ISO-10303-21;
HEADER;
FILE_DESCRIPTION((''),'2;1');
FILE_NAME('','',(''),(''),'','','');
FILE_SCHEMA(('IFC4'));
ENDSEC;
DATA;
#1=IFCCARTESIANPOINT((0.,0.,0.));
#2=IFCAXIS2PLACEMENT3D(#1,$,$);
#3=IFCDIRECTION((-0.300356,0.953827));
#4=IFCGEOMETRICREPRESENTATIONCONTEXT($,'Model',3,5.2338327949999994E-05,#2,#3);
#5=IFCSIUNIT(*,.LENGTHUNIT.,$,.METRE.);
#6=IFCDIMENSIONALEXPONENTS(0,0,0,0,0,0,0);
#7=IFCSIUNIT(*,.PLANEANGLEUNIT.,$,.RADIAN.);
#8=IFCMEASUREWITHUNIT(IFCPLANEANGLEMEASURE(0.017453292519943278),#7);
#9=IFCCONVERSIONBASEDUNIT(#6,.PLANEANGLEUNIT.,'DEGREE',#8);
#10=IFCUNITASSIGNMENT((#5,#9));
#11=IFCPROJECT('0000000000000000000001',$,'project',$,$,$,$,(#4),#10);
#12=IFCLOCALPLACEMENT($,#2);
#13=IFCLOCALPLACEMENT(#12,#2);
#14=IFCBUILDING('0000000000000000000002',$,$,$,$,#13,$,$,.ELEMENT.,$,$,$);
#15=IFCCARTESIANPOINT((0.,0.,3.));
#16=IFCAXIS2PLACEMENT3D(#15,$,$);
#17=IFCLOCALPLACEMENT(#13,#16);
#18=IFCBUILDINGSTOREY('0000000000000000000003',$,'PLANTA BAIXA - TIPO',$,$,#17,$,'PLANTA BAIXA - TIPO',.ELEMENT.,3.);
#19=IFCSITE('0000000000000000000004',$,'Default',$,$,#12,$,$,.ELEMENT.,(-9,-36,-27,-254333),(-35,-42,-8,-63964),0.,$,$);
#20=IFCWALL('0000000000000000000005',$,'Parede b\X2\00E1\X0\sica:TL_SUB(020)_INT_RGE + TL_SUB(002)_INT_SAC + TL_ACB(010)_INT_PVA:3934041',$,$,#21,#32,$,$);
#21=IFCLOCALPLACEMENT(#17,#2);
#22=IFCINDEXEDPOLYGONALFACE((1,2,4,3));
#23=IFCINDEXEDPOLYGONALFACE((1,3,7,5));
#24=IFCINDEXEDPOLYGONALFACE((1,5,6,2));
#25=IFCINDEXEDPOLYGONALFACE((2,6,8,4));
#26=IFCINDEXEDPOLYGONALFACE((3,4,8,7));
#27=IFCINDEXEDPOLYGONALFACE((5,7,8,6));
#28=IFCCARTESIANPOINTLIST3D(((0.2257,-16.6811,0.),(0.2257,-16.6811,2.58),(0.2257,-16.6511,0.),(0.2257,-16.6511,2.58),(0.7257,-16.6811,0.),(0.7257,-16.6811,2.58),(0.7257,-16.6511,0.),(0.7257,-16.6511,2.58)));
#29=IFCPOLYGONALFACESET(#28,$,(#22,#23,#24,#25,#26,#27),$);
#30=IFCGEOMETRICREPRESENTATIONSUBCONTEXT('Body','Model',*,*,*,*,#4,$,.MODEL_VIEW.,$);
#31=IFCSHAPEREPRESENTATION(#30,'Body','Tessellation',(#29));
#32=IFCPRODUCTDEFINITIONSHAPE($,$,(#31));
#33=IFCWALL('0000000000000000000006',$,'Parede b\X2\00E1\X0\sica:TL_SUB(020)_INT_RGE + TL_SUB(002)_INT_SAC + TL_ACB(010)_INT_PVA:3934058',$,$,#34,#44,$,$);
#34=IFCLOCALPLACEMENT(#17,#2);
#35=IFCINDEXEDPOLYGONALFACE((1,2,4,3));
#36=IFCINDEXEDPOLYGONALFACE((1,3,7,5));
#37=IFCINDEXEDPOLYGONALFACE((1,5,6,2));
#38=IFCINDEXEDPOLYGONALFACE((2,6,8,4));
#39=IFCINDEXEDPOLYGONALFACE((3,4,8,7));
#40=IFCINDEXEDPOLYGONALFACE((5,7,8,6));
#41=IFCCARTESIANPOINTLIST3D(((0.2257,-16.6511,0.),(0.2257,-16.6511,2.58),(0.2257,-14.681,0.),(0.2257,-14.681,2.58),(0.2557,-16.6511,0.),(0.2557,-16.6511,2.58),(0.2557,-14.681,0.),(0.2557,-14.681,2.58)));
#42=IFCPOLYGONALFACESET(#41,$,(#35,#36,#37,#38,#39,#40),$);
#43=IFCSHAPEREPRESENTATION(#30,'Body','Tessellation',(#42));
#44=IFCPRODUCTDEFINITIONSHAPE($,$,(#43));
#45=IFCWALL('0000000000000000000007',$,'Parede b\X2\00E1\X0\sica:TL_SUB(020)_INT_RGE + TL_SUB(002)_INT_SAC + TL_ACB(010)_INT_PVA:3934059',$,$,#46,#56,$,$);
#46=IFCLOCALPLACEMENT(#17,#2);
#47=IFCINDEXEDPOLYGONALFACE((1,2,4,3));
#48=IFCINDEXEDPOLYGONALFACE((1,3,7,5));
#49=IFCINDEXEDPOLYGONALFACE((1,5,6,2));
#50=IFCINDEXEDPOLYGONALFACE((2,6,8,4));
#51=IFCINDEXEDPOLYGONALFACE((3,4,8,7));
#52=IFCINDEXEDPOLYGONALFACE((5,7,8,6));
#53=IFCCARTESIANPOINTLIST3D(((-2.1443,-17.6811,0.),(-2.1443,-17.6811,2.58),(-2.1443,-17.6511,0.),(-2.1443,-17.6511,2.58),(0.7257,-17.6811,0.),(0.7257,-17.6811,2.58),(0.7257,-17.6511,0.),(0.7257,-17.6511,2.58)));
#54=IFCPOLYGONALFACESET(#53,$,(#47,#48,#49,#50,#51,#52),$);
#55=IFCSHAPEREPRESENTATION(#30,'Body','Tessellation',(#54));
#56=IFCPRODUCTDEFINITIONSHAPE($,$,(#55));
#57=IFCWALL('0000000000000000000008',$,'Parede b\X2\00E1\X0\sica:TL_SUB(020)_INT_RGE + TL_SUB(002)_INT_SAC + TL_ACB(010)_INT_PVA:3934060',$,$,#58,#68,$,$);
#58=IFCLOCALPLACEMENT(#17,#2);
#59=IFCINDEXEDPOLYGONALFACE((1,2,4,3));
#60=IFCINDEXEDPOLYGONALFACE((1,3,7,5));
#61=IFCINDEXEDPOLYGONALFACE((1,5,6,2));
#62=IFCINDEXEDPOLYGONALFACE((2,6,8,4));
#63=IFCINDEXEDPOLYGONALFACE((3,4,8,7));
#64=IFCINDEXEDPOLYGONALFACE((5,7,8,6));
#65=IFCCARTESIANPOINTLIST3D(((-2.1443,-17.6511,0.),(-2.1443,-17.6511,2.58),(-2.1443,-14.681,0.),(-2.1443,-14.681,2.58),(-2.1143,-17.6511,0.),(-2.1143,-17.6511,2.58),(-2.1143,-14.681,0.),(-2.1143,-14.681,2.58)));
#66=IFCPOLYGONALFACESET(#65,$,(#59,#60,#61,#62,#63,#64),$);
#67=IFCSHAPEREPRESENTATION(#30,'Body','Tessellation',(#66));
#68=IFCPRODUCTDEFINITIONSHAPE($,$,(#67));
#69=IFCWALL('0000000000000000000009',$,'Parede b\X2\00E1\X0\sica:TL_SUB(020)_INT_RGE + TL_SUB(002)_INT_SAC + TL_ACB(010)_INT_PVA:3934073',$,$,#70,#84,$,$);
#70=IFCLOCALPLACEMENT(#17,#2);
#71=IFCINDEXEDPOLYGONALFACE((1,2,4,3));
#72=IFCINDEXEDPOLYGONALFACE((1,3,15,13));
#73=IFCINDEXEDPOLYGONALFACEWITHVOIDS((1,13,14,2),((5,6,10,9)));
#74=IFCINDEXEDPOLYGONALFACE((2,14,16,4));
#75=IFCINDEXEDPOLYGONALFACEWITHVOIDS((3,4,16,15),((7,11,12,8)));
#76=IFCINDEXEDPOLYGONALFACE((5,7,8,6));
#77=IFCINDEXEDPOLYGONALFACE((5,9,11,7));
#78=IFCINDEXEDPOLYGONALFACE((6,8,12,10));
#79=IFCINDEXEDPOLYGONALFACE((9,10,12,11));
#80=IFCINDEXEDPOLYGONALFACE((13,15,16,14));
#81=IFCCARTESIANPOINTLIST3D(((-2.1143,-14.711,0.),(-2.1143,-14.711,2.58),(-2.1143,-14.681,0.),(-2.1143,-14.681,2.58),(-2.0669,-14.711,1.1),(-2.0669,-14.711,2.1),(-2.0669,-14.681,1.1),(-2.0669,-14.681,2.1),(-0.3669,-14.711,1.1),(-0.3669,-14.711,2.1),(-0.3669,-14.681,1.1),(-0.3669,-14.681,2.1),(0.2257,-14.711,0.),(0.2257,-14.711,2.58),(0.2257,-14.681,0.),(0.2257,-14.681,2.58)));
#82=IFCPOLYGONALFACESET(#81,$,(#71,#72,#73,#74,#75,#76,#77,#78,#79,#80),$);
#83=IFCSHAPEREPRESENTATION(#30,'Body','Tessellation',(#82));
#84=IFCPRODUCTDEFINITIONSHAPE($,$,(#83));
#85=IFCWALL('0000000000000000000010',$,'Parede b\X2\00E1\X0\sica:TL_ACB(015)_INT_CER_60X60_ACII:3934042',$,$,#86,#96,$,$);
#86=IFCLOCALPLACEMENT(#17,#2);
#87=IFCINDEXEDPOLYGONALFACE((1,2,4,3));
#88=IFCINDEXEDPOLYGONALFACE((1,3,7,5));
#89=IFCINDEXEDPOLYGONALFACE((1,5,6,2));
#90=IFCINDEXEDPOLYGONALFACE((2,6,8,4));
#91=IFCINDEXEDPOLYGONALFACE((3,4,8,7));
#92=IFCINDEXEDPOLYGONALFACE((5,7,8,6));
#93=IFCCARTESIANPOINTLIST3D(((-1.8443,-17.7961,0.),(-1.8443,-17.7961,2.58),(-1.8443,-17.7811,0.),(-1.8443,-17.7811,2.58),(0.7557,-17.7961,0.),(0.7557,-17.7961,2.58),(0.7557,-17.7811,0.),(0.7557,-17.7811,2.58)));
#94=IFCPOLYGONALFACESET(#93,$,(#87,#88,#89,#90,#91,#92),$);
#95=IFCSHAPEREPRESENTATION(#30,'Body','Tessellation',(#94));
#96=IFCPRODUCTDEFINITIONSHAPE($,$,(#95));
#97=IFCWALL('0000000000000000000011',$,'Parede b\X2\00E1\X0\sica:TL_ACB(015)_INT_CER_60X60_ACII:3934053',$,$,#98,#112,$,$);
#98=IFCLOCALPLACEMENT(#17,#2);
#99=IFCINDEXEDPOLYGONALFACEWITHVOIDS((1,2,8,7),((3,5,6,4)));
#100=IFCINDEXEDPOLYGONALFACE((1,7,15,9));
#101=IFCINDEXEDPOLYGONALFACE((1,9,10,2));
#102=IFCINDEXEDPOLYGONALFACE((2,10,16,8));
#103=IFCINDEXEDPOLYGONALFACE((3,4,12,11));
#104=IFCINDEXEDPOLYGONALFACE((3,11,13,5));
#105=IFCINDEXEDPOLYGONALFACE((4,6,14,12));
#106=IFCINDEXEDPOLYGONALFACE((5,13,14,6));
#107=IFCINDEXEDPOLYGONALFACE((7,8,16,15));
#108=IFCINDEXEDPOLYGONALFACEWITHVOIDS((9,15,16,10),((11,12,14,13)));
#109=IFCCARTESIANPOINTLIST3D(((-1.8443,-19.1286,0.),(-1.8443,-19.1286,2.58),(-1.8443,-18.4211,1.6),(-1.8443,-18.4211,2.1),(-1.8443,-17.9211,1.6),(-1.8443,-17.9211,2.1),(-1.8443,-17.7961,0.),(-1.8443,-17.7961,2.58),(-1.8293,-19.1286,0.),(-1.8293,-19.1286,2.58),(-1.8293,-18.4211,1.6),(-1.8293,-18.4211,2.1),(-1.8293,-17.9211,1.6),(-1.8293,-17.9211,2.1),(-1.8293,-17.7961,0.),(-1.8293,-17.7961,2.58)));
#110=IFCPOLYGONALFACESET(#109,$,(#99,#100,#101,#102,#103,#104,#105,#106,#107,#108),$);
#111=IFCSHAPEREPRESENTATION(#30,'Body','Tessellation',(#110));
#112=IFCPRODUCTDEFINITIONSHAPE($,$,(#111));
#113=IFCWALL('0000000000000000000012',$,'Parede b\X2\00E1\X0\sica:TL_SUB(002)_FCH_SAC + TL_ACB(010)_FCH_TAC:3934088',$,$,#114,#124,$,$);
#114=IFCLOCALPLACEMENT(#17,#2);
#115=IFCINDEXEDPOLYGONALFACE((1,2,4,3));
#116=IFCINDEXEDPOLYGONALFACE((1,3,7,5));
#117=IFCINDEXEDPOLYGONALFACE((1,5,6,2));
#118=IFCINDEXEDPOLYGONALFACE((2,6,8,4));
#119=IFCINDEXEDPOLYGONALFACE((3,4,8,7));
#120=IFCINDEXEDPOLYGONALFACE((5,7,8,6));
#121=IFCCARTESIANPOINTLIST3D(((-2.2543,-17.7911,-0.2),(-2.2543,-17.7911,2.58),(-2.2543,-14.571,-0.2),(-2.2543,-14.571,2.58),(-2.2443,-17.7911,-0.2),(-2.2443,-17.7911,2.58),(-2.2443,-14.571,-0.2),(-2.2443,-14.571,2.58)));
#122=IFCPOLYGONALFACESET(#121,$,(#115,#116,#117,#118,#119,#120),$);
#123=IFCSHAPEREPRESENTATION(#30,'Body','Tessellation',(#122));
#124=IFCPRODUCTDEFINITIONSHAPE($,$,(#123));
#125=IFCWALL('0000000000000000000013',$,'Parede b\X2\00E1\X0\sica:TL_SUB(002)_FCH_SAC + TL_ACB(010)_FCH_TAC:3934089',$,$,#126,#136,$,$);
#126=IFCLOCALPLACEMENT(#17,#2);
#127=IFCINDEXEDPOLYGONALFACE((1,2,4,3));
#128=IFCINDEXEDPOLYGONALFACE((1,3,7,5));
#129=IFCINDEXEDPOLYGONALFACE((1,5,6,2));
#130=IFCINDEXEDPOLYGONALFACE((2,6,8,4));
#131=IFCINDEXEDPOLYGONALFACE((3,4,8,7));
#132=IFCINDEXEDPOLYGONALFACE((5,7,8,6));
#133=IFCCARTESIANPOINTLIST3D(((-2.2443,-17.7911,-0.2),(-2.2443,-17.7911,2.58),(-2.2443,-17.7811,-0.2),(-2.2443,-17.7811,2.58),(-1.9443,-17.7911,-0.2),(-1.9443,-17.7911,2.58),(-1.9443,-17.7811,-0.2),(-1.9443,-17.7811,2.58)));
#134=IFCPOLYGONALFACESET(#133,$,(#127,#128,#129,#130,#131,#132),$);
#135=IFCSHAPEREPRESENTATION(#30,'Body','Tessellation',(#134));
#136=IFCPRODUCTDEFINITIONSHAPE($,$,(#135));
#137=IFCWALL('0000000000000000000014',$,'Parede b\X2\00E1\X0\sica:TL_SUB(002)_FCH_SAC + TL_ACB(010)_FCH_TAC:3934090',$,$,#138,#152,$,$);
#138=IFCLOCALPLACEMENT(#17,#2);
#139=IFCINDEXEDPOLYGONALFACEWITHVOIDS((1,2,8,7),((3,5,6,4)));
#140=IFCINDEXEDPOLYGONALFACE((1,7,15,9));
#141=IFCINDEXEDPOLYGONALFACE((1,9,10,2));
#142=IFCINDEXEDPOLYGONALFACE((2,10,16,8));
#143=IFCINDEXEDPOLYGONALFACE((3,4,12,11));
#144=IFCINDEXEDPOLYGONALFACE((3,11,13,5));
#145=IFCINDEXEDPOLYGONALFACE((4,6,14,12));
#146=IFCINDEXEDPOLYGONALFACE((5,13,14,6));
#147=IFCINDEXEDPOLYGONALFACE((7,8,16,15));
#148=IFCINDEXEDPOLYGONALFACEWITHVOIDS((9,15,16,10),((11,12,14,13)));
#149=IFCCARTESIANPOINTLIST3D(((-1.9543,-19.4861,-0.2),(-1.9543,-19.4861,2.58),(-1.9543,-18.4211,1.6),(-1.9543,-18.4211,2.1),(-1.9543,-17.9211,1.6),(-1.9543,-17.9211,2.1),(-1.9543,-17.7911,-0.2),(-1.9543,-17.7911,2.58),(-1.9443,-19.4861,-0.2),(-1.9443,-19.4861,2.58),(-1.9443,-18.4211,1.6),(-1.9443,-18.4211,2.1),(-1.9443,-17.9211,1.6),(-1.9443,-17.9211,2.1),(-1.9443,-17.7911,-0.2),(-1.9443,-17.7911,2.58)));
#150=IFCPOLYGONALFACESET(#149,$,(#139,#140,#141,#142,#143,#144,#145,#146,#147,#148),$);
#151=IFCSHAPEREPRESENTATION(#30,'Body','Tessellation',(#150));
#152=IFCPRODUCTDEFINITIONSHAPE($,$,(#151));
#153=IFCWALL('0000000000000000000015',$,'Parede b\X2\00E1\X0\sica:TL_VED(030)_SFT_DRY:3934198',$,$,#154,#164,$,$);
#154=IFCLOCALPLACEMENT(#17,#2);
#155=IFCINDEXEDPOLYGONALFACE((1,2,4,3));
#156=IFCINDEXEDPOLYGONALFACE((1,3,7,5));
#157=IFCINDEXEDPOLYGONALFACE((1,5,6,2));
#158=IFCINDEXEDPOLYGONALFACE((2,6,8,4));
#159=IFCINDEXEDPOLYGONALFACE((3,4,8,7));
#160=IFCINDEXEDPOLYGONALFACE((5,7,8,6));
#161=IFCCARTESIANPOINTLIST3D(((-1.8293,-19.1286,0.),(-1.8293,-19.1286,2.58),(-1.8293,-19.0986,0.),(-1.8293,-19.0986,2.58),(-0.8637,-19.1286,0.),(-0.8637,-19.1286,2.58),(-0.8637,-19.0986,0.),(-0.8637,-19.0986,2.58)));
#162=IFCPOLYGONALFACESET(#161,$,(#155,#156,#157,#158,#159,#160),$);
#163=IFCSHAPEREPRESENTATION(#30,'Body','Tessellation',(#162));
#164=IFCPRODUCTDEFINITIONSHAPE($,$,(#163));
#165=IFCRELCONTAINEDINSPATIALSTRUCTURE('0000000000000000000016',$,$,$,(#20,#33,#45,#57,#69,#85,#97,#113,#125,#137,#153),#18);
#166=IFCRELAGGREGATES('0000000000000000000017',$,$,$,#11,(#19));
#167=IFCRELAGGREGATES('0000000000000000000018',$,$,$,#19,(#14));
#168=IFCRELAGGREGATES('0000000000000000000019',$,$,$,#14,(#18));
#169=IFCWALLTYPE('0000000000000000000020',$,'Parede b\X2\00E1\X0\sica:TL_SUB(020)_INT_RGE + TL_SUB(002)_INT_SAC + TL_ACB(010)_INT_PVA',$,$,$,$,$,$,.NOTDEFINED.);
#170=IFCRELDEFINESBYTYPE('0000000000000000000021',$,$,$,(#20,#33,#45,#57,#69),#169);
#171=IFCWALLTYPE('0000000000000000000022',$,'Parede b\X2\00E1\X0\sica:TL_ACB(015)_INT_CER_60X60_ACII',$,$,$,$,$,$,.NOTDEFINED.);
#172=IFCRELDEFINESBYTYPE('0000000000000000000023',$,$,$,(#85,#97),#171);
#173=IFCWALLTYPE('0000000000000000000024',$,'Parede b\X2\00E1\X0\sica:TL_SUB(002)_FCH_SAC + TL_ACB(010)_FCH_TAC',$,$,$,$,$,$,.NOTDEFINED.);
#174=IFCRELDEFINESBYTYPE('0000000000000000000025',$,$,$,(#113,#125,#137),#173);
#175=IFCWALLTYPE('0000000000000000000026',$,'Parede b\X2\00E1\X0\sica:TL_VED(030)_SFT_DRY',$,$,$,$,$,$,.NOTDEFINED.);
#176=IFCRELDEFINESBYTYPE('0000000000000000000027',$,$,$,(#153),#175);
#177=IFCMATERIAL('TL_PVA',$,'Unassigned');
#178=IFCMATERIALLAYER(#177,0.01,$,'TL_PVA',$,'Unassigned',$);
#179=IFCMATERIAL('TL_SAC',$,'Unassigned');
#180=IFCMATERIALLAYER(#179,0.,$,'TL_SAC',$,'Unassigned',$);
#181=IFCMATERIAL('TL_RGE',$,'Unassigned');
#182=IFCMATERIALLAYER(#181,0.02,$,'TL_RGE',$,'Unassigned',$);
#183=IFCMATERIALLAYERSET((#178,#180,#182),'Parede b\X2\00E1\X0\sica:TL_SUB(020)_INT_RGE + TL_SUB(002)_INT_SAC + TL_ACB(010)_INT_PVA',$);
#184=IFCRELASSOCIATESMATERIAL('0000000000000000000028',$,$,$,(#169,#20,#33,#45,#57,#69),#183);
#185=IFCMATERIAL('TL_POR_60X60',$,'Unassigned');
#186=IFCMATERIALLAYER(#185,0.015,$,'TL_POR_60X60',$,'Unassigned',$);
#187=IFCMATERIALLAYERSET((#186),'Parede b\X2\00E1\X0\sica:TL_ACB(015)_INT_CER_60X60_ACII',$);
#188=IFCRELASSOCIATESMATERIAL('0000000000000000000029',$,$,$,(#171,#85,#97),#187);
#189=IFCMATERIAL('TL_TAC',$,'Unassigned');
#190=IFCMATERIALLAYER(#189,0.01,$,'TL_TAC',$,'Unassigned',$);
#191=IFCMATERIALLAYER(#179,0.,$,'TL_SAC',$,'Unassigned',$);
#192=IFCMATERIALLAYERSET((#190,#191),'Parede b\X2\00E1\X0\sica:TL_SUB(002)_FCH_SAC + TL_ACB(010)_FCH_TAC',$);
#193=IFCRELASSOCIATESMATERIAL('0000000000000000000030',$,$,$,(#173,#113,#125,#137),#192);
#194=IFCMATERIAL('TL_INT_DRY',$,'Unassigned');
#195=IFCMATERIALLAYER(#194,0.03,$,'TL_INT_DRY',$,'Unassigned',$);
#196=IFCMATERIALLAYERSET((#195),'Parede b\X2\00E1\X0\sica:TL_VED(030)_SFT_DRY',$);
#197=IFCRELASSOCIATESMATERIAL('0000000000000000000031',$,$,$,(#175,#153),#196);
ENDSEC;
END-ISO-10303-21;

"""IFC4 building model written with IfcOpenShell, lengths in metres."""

from ifc_helpers import new_model, entity, si_unit, converted_unit, direction, frame, frame_2d, origin, place, context, subcontext, project, spatial, rectangle, extrude, material, layer, layer_set, layer_usage, type_object, element, save


model = new_model("IFC4")

# Units and contexts
model_context = context("Model", 3, precision=5.2338327949999994e-05, world=origin(), true_north=direction((-0.300356, 0.953827)))
body_context = subcontext(model_context, "Body", "Model", "MODEL_VIEW")
ifc_project = project(units=[si_unit("LENGTHUNIT", "METRE"), converted_unit("PLANEANGLEUNIT", "DEGREE", entity("IfcPlaneAngleMeasure", 0.017453292519943278), si_unit("PLANEANGLEUNIT", "RADIAN"), dimensions=[0, 0, 0, 0, 0, 0, 0])], contexts=[model_context])

# Site, building, storey
site_placement = place(None, origin())
site = spatial("IfcSite", under=ifc_project, at=site_placement, Name="Default", CompositionType="ELEMENT", RefLatitude=(-9, -36, -27, -254333), RefLongitude=(-35, -42, -8, -63964), RefElevation=0.0)
building_placement = place(site_placement, origin())
building = spatial("IfcBuilding", under=site, at=building_placement, CompositionType="ELEMENT")
storey_placement = place(building_placement, frame((0.0, 0.0, 3.0)))
storey = spatial("IfcBuildingStorey", under=building, at=storey_placement, Name="PLANTA BAIXA - TIPO", LongName="PLANTA BAIXA - TIPO", CompositionType="ELEMENT", Elevation=3.0)

# Shared definitions
ifc_material_1 = material(Name="TL_POR_60X60", Category="Unassigned")

# Walls
ifc_material_2 = material(Name="TL_PVA", Category="Unassigned")
ifc_layer_1 = layer(ifc_material_2, 0.01, Name="TL_PVA", Category="Unassigned")
ifc_material_3 = material(Name="TL_SAC", Category="Unassigned")
ifc_layer_2 = layer(ifc_material_3, 0.0, Name="TL_SAC", Category="Unassigned")
ifc_material_4 = material(Name="TL_RGE", Category="Unassigned")
ifc_layer_3 = layer(ifc_material_4, 0.02, Name="TL_RGE", Category="Unassigned")
ifc_layer_set_1 = layer_set([ifc_layer_1, ifc_layer_2, ifc_layer_3], Name="Parede básica:TL_SUB(020)_INT_RGE + TL_SUB(002)_INT_SAC + TL_ACB(010)_INT_PVA")
ifc_layer_usage_1 = layer_usage(ifc_layer_set_1, "AXIS2", "POSITIVE", -0.015)
wall_type_1 = type_object("IfcWallType", Name="Parede básica:TL_SUB(020)_INT_RGE + TL_SUB(002)_INT_SAC + TL_ACB(010)_INT_PVA", PredefinedType="NOTDEFINED", material=ifc_layer_set_1)
wall_1_placement = place(storey_placement, frame((0.2257, -16.6661, 0.0)))
element("IfcWall", 1, at=wall_1_placement, inside=storey, type_object=wall_type_1, material=ifc_layer_usage_1, Name="Parede básica:TL_SUB(020)_INT_RGE + TL_SUB(002)_INT_SAC + TL_ACB(010)_INT_PVA:3934041", context=body_context, shape_type="SweptSolid", body=[
    extrude(rectangle(XDim=0.5, YDim=0.03, at=frame_2d((0.25, 0.0), x_axis=(-1.0, 0.0))), origin(), (0.0, 0.0, 1.0), 2.58),
])
ifc_layer_usage_2 = layer_usage(ifc_layer_set_1, "AXIS2", "NEGATIVE", 0.015)
wall_2_placement = place(storey_placement, frame((0.2407, -16.6511, 0.0), z_axis=(0.0, 0.0, 1.0), x_axis=(0.0, 1.0, 0.0)))
element("IfcWall", 2, at=wall_2_placement, inside=storey, type_object=wall_type_1, material=ifc_layer_usage_2, Name="Parede básica:TL_SUB(020)_INT_RGE + TL_SUB(002)_INT_SAC + TL_ACB(010)_INT_PVA:3934058", context=body_context, shape_type="SweptSolid", body=[
    extrude(rectangle(XDim=1.9701, YDim=0.03, at=frame_2d((0.9851, 0.0), x_axis=(-1.0, 0.0))), origin(), (0.0, 0.0, 1.0), 2.58),
])
ifc_layer_usage_3 = layer_usage(ifc_layer_set_1, "AXIS2", "NEGATIVE", 0.015)
wall_3_placement = place(storey_placement, frame((-2.1443, -17.6661, 0.0)))
element("IfcWall", 3, at=wall_3_placement, inside=storey, type_object=wall_type_1, material=ifc_layer_usage_3, Name="Parede básica:TL_SUB(020)_INT_RGE + TL_SUB(002)_INT_SAC + TL_ACB(010)_INT_PVA:3934059", context=body_context, shape_type="SweptSolid", body=[
    extrude(rectangle(XDim=2.87, YDim=0.03, at=frame_2d((1.435, 0.0), x_axis=(-1.0, 0.0))), origin(), (0.0, 0.0, 1.0), 2.58),
])
ifc_layer_usage_4 = layer_usage(ifc_layer_set_1, "AXIS2", "NEGATIVE", 0.015)
wall_4_placement = place(storey_placement, frame((-2.1293, -14.681, 0.0), z_axis=(0.0, 0.0, 1.0), x_axis=(0.0, -1.0, 0.0)))
element("IfcWall", 4, at=wall_4_placement, inside=storey, type_object=wall_type_1, material=ifc_layer_usage_4, Name="Parede básica:TL_SUB(020)_INT_RGE + TL_SUB(002)_INT_SAC + TL_ACB(010)_INT_PVA:3934060", context=body_context, shape_type="SweptSolid", body=[
    extrude(rectangle(XDim=2.9701, YDim=0.03, at=frame_2d((1.4851, 0.0), x_axis=(-1.0, 0.0))), origin(), (0.0, 0.0, 1.0), 2.58),
])

# Wall, opening
ifc_layer_usage_5 = layer_usage(ifc_layer_set_1, "AXIS2", "NEGATIVE", 0.015)
wall_5_placement = place(storey_placement, frame((0.2257, -14.696, 0.0), z_axis=(0.0, 0.0, 1.0), x_axis=(-1.0, 0.0, 0.0)))
wall_5 = element("IfcWall", 5, at=wall_5_placement, inside=storey, type_object=wall_type_1, material=ifc_layer_usage_5, Name="Parede básica:TL_SUB(020)_INT_RGE + TL_SUB(002)_INT_SAC + TL_ACB(010)_INT_PVA:3934073", context=body_context, shape_type="SweptSolid", body=[
    extrude(rectangle(XDim=2.34, YDim=0.03, at=frame_2d((1.17, 0.0), x_axis=(-1.0, 0.0))), origin(), (0.0, 0.0, 1.0), 2.58),
])
opening_1_placement = place(wall_5_placement, frame((0.2257, -14.696, 1.1)))
element("IfcOpeningElement", 6, at=opening_1_placement, cuts=wall_5, PredefinedType="OPENING", context=body_context, shape_type="SweptSolid", body=[
    extrude(rectangle(XDim=1.0, YDim=1.7, at=frame_2d((0.0, 0.0), x_axis=(0.0, 1.0))), frame((1.2169, 13.157, 0.5), z_axis=(0.0, 1.0, 0.0), x_axis=(1.0, 0.0, 0.0)), (0.0, 0.0, 1.0), 3.048),
])

# Wall
ifc_layer_4 = layer(ifc_material_1, 0.015, Name="TL_POR_60X60", Category="Unassigned")
ifc_layer_set_2 = layer_set([ifc_layer_4], Name="Parede básica:TL_ACB(015)_INT_CER_60X60_ACII")
ifc_layer_usage_6 = layer_usage(ifc_layer_set_2, "AXIS2", "POSITIVE", -0.0075)
wall_type_2 = type_object("IfcWallType", Name="Parede básica:TL_ACB(015)_INT_CER_60X60_ACII", PredefinedType="NOTDEFINED", material=ifc_layer_set_2)
wall_6_placement = place(storey_placement, frame((-1.8443, -17.7886, 0.0)))
element("IfcWall", 7, at=wall_6_placement, inside=storey, type_object=wall_type_2, material=ifc_layer_usage_6, Name="Parede básica:TL_ACB(015)_INT_CER_60X60_ACII:3934042", context=body_context, shape_type="SweptSolid", body=[
    extrude(rectangle(XDim=2.6, YDim=0.015, at=frame_2d((1.3, 0.0), x_axis=(-1.0, 0.0))), origin(), (0.0, 0.0, 1.0), 2.58),
])

# Wall, opening
ifc_layer_usage_7 = layer_usage(ifc_layer_set_2, "AXIS2", "NEGATIVE", 0.0075)
wall_7_placement = place(storey_placement, frame((-1.8368, -17.7961, 0.0), z_axis=(0.0, 0.0, 1.0), x_axis=(0.0, -1.0, 0.0)))
wall_7 = element("IfcWall", 8, at=wall_7_placement, inside=storey, type_object=wall_type_2, material=ifc_layer_usage_7, Name="Parede básica:TL_ACB(015)_INT_CER_60X60_ACII:3934053", context=body_context, shape_type="SweptSolid", body=[
    extrude(rectangle(XDim=1.3325, YDim=0.015, at=frame_2d((0.6662, 0.0), x_axis=(-1.0, 0.0))), origin(), (0.0, 0.0, 1.0), 2.58),
])
opening_2_placement = place(wall_7_placement, frame((-17.7961, 1.8368, 1.6)))
element("IfcOpeningElement", 9, at=opening_2_placement, cuts=wall_7, PredefinedType="OPENING", context=body_context, shape_type="SweptSolid", body=[
    extrude(rectangle(XDim=0.5, YDim=0.5, at=frame_2d((0.0, 0.0), x_axis=(1.0, 0.0))), frame((18.1711, -3.4683, 0.25), z_axis=(0.0, 1.0, 0.0), x_axis=(0.0, 0.0, 1.0)), (0.0, 0.0, 1.0), 3.048),
])

# Walls
ifc_material_5 = material(Name="TL_TAC", Category="Unassigned")
ifc_layer_5 = layer(ifc_material_5, 0.01, Name="TL_TAC", Category="Unassigned")
ifc_layer_6 = layer(ifc_material_3, 0.0, Name="TL_SAC", Category="Unassigned")
ifc_layer_set_3 = layer_set([ifc_layer_5, ifc_layer_6], Name="Parede básica:TL_SUB(002)_FCH_SAC + TL_ACB(010)_FCH_TAC")
ifc_layer_usage_8 = layer_usage(ifc_layer_set_3, "AXIS2", "NEGATIVE", 0.005)
wall_type_3 = type_object("IfcWallType", Name="Parede básica:TL_SUB(002)_FCH_SAC + TL_ACB(010)_FCH_TAC", PredefinedType="NOTDEFINED", material=ifc_layer_set_3)
wall_8_placement = place(storey_placement, frame((-2.2493, -14.571, -0.2), z_axis=(0.0, 0.0, 1.0), x_axis=(0.0, -1.0, 0.0)))
element("IfcWall", 10, at=wall_8_placement, inside=storey, type_object=wall_type_3, material=ifc_layer_usage_8, Name="Parede básica:TL_SUB(002)_FCH_SAC + TL_ACB(010)_FCH_TAC:3934088", context=body_context, shape_type="SweptSolid", body=[
    extrude(rectangle(XDim=3.2201, YDim=0.01, at=frame_2d((1.6101, 0.0), x_axis=(-1.0, 0.0))), origin(), (0.0, 0.0, 1.0), 2.78),
])
ifc_layer_usage_9 = layer_usage(ifc_layer_set_3, "AXIS2", "NEGATIVE", 0.005)
wall_9_placement = place(storey_placement, frame((-2.2443, -17.7861, -0.2)))
element("IfcWall", 11, at=wall_9_placement, inside=storey, type_object=wall_type_3, material=ifc_layer_usage_9, Name="Parede básica:TL_SUB(002)_FCH_SAC + TL_ACB(010)_FCH_TAC:3934089", context=body_context, shape_type="SweptSolid", body=[
    extrude(rectangle(XDim=0.3, YDim=0.01, at=frame_2d((0.15, 0.0), x_axis=(-1.0, 0.0))), origin(), (0.0, 0.0, 1.0), 2.78),
])

# Wall, opening
ifc_layer_usage_10 = layer_usage(ifc_layer_set_3, "AXIS2", "NEGATIVE", 0.005)
wall_10_placement = place(storey_placement, frame((-1.9493, -17.7911, -0.2), z_axis=(0.0, 0.0, 1.0), x_axis=(0.0, -1.0, 0.0)))
wall_10 = element("IfcWall", 12, at=wall_10_placement, inside=storey, type_object=wall_type_3, material=ifc_layer_usage_10, Name="Parede básica:TL_SUB(002)_FCH_SAC + TL_ACB(010)_FCH_TAC:3934090", context=body_context, shape_type="SweptSolid", body=[
    extrude(rectangle(XDim=1.695, YDim=0.01, at=frame_2d((0.8475, 0.0), x_axis=(-1.0, 0.0))), origin(), (0.0, 0.0, 1.0), 2.78),
])
opening_3_placement = place(wall_10_placement, frame((-17.7911, 1.9493, 1.8)))
element("IfcOpeningElement", 13, at=opening_3_placement, cuts=wall_10, PredefinedType="OPENING", context=body_context, shape_type="SweptSolid", body=[
    extrude(rectangle(XDim=0.5, YDim=0.5, at=frame_2d((0.0, 0.0), x_axis=(1.0, 0.0))), frame((18.1711, -3.4683, 0.25), z_axis=(0.0, 1.0, 0.0), x_axis=(0.0, 0.0, 1.0)), (0.0, 0.0, 1.0), 3.048),
])

# Wall
ifc_material_6 = material(Name="TL_INT_DRY", Category="Unassigned")
ifc_layer_7 = layer(ifc_material_6, 0.03, Name="TL_INT_DRY", Category="Unassigned")
ifc_layer_set_4 = layer_set([ifc_layer_7], Name="Parede básica:TL_VED(030)_SFT_DRY")
ifc_layer_usage_11 = layer_usage(ifc_layer_set_4, "AXIS2", "NEGATIVE", 0.015)
wall_type_4 = type_object("IfcWallType", Name="Parede básica:TL_VED(030)_SFT_DRY", PredefinedType="NOTDEFINED", material=ifc_layer_set_4)
wall_11_placement = place(storey_placement, frame((-1.8293, -19.1136, 0.0)))
element("IfcWall", 14, at=wall_11_placement, inside=storey, type_object=wall_type_4, material=ifc_layer_usage_11, Name="Parede básica:TL_VED(030)_SFT_DRY:3934198", context=body_context, shape_type="SweptSolid", body=[
    extrude(rectangle(XDim=0.9655, YDim=0.03, at=frame_2d((0.4828, 0.0), x_axis=(-1.0, 0.0))), origin(), (0.0, 0.0, 1.0), 2.58),
])

save(model, "model.ifc")
